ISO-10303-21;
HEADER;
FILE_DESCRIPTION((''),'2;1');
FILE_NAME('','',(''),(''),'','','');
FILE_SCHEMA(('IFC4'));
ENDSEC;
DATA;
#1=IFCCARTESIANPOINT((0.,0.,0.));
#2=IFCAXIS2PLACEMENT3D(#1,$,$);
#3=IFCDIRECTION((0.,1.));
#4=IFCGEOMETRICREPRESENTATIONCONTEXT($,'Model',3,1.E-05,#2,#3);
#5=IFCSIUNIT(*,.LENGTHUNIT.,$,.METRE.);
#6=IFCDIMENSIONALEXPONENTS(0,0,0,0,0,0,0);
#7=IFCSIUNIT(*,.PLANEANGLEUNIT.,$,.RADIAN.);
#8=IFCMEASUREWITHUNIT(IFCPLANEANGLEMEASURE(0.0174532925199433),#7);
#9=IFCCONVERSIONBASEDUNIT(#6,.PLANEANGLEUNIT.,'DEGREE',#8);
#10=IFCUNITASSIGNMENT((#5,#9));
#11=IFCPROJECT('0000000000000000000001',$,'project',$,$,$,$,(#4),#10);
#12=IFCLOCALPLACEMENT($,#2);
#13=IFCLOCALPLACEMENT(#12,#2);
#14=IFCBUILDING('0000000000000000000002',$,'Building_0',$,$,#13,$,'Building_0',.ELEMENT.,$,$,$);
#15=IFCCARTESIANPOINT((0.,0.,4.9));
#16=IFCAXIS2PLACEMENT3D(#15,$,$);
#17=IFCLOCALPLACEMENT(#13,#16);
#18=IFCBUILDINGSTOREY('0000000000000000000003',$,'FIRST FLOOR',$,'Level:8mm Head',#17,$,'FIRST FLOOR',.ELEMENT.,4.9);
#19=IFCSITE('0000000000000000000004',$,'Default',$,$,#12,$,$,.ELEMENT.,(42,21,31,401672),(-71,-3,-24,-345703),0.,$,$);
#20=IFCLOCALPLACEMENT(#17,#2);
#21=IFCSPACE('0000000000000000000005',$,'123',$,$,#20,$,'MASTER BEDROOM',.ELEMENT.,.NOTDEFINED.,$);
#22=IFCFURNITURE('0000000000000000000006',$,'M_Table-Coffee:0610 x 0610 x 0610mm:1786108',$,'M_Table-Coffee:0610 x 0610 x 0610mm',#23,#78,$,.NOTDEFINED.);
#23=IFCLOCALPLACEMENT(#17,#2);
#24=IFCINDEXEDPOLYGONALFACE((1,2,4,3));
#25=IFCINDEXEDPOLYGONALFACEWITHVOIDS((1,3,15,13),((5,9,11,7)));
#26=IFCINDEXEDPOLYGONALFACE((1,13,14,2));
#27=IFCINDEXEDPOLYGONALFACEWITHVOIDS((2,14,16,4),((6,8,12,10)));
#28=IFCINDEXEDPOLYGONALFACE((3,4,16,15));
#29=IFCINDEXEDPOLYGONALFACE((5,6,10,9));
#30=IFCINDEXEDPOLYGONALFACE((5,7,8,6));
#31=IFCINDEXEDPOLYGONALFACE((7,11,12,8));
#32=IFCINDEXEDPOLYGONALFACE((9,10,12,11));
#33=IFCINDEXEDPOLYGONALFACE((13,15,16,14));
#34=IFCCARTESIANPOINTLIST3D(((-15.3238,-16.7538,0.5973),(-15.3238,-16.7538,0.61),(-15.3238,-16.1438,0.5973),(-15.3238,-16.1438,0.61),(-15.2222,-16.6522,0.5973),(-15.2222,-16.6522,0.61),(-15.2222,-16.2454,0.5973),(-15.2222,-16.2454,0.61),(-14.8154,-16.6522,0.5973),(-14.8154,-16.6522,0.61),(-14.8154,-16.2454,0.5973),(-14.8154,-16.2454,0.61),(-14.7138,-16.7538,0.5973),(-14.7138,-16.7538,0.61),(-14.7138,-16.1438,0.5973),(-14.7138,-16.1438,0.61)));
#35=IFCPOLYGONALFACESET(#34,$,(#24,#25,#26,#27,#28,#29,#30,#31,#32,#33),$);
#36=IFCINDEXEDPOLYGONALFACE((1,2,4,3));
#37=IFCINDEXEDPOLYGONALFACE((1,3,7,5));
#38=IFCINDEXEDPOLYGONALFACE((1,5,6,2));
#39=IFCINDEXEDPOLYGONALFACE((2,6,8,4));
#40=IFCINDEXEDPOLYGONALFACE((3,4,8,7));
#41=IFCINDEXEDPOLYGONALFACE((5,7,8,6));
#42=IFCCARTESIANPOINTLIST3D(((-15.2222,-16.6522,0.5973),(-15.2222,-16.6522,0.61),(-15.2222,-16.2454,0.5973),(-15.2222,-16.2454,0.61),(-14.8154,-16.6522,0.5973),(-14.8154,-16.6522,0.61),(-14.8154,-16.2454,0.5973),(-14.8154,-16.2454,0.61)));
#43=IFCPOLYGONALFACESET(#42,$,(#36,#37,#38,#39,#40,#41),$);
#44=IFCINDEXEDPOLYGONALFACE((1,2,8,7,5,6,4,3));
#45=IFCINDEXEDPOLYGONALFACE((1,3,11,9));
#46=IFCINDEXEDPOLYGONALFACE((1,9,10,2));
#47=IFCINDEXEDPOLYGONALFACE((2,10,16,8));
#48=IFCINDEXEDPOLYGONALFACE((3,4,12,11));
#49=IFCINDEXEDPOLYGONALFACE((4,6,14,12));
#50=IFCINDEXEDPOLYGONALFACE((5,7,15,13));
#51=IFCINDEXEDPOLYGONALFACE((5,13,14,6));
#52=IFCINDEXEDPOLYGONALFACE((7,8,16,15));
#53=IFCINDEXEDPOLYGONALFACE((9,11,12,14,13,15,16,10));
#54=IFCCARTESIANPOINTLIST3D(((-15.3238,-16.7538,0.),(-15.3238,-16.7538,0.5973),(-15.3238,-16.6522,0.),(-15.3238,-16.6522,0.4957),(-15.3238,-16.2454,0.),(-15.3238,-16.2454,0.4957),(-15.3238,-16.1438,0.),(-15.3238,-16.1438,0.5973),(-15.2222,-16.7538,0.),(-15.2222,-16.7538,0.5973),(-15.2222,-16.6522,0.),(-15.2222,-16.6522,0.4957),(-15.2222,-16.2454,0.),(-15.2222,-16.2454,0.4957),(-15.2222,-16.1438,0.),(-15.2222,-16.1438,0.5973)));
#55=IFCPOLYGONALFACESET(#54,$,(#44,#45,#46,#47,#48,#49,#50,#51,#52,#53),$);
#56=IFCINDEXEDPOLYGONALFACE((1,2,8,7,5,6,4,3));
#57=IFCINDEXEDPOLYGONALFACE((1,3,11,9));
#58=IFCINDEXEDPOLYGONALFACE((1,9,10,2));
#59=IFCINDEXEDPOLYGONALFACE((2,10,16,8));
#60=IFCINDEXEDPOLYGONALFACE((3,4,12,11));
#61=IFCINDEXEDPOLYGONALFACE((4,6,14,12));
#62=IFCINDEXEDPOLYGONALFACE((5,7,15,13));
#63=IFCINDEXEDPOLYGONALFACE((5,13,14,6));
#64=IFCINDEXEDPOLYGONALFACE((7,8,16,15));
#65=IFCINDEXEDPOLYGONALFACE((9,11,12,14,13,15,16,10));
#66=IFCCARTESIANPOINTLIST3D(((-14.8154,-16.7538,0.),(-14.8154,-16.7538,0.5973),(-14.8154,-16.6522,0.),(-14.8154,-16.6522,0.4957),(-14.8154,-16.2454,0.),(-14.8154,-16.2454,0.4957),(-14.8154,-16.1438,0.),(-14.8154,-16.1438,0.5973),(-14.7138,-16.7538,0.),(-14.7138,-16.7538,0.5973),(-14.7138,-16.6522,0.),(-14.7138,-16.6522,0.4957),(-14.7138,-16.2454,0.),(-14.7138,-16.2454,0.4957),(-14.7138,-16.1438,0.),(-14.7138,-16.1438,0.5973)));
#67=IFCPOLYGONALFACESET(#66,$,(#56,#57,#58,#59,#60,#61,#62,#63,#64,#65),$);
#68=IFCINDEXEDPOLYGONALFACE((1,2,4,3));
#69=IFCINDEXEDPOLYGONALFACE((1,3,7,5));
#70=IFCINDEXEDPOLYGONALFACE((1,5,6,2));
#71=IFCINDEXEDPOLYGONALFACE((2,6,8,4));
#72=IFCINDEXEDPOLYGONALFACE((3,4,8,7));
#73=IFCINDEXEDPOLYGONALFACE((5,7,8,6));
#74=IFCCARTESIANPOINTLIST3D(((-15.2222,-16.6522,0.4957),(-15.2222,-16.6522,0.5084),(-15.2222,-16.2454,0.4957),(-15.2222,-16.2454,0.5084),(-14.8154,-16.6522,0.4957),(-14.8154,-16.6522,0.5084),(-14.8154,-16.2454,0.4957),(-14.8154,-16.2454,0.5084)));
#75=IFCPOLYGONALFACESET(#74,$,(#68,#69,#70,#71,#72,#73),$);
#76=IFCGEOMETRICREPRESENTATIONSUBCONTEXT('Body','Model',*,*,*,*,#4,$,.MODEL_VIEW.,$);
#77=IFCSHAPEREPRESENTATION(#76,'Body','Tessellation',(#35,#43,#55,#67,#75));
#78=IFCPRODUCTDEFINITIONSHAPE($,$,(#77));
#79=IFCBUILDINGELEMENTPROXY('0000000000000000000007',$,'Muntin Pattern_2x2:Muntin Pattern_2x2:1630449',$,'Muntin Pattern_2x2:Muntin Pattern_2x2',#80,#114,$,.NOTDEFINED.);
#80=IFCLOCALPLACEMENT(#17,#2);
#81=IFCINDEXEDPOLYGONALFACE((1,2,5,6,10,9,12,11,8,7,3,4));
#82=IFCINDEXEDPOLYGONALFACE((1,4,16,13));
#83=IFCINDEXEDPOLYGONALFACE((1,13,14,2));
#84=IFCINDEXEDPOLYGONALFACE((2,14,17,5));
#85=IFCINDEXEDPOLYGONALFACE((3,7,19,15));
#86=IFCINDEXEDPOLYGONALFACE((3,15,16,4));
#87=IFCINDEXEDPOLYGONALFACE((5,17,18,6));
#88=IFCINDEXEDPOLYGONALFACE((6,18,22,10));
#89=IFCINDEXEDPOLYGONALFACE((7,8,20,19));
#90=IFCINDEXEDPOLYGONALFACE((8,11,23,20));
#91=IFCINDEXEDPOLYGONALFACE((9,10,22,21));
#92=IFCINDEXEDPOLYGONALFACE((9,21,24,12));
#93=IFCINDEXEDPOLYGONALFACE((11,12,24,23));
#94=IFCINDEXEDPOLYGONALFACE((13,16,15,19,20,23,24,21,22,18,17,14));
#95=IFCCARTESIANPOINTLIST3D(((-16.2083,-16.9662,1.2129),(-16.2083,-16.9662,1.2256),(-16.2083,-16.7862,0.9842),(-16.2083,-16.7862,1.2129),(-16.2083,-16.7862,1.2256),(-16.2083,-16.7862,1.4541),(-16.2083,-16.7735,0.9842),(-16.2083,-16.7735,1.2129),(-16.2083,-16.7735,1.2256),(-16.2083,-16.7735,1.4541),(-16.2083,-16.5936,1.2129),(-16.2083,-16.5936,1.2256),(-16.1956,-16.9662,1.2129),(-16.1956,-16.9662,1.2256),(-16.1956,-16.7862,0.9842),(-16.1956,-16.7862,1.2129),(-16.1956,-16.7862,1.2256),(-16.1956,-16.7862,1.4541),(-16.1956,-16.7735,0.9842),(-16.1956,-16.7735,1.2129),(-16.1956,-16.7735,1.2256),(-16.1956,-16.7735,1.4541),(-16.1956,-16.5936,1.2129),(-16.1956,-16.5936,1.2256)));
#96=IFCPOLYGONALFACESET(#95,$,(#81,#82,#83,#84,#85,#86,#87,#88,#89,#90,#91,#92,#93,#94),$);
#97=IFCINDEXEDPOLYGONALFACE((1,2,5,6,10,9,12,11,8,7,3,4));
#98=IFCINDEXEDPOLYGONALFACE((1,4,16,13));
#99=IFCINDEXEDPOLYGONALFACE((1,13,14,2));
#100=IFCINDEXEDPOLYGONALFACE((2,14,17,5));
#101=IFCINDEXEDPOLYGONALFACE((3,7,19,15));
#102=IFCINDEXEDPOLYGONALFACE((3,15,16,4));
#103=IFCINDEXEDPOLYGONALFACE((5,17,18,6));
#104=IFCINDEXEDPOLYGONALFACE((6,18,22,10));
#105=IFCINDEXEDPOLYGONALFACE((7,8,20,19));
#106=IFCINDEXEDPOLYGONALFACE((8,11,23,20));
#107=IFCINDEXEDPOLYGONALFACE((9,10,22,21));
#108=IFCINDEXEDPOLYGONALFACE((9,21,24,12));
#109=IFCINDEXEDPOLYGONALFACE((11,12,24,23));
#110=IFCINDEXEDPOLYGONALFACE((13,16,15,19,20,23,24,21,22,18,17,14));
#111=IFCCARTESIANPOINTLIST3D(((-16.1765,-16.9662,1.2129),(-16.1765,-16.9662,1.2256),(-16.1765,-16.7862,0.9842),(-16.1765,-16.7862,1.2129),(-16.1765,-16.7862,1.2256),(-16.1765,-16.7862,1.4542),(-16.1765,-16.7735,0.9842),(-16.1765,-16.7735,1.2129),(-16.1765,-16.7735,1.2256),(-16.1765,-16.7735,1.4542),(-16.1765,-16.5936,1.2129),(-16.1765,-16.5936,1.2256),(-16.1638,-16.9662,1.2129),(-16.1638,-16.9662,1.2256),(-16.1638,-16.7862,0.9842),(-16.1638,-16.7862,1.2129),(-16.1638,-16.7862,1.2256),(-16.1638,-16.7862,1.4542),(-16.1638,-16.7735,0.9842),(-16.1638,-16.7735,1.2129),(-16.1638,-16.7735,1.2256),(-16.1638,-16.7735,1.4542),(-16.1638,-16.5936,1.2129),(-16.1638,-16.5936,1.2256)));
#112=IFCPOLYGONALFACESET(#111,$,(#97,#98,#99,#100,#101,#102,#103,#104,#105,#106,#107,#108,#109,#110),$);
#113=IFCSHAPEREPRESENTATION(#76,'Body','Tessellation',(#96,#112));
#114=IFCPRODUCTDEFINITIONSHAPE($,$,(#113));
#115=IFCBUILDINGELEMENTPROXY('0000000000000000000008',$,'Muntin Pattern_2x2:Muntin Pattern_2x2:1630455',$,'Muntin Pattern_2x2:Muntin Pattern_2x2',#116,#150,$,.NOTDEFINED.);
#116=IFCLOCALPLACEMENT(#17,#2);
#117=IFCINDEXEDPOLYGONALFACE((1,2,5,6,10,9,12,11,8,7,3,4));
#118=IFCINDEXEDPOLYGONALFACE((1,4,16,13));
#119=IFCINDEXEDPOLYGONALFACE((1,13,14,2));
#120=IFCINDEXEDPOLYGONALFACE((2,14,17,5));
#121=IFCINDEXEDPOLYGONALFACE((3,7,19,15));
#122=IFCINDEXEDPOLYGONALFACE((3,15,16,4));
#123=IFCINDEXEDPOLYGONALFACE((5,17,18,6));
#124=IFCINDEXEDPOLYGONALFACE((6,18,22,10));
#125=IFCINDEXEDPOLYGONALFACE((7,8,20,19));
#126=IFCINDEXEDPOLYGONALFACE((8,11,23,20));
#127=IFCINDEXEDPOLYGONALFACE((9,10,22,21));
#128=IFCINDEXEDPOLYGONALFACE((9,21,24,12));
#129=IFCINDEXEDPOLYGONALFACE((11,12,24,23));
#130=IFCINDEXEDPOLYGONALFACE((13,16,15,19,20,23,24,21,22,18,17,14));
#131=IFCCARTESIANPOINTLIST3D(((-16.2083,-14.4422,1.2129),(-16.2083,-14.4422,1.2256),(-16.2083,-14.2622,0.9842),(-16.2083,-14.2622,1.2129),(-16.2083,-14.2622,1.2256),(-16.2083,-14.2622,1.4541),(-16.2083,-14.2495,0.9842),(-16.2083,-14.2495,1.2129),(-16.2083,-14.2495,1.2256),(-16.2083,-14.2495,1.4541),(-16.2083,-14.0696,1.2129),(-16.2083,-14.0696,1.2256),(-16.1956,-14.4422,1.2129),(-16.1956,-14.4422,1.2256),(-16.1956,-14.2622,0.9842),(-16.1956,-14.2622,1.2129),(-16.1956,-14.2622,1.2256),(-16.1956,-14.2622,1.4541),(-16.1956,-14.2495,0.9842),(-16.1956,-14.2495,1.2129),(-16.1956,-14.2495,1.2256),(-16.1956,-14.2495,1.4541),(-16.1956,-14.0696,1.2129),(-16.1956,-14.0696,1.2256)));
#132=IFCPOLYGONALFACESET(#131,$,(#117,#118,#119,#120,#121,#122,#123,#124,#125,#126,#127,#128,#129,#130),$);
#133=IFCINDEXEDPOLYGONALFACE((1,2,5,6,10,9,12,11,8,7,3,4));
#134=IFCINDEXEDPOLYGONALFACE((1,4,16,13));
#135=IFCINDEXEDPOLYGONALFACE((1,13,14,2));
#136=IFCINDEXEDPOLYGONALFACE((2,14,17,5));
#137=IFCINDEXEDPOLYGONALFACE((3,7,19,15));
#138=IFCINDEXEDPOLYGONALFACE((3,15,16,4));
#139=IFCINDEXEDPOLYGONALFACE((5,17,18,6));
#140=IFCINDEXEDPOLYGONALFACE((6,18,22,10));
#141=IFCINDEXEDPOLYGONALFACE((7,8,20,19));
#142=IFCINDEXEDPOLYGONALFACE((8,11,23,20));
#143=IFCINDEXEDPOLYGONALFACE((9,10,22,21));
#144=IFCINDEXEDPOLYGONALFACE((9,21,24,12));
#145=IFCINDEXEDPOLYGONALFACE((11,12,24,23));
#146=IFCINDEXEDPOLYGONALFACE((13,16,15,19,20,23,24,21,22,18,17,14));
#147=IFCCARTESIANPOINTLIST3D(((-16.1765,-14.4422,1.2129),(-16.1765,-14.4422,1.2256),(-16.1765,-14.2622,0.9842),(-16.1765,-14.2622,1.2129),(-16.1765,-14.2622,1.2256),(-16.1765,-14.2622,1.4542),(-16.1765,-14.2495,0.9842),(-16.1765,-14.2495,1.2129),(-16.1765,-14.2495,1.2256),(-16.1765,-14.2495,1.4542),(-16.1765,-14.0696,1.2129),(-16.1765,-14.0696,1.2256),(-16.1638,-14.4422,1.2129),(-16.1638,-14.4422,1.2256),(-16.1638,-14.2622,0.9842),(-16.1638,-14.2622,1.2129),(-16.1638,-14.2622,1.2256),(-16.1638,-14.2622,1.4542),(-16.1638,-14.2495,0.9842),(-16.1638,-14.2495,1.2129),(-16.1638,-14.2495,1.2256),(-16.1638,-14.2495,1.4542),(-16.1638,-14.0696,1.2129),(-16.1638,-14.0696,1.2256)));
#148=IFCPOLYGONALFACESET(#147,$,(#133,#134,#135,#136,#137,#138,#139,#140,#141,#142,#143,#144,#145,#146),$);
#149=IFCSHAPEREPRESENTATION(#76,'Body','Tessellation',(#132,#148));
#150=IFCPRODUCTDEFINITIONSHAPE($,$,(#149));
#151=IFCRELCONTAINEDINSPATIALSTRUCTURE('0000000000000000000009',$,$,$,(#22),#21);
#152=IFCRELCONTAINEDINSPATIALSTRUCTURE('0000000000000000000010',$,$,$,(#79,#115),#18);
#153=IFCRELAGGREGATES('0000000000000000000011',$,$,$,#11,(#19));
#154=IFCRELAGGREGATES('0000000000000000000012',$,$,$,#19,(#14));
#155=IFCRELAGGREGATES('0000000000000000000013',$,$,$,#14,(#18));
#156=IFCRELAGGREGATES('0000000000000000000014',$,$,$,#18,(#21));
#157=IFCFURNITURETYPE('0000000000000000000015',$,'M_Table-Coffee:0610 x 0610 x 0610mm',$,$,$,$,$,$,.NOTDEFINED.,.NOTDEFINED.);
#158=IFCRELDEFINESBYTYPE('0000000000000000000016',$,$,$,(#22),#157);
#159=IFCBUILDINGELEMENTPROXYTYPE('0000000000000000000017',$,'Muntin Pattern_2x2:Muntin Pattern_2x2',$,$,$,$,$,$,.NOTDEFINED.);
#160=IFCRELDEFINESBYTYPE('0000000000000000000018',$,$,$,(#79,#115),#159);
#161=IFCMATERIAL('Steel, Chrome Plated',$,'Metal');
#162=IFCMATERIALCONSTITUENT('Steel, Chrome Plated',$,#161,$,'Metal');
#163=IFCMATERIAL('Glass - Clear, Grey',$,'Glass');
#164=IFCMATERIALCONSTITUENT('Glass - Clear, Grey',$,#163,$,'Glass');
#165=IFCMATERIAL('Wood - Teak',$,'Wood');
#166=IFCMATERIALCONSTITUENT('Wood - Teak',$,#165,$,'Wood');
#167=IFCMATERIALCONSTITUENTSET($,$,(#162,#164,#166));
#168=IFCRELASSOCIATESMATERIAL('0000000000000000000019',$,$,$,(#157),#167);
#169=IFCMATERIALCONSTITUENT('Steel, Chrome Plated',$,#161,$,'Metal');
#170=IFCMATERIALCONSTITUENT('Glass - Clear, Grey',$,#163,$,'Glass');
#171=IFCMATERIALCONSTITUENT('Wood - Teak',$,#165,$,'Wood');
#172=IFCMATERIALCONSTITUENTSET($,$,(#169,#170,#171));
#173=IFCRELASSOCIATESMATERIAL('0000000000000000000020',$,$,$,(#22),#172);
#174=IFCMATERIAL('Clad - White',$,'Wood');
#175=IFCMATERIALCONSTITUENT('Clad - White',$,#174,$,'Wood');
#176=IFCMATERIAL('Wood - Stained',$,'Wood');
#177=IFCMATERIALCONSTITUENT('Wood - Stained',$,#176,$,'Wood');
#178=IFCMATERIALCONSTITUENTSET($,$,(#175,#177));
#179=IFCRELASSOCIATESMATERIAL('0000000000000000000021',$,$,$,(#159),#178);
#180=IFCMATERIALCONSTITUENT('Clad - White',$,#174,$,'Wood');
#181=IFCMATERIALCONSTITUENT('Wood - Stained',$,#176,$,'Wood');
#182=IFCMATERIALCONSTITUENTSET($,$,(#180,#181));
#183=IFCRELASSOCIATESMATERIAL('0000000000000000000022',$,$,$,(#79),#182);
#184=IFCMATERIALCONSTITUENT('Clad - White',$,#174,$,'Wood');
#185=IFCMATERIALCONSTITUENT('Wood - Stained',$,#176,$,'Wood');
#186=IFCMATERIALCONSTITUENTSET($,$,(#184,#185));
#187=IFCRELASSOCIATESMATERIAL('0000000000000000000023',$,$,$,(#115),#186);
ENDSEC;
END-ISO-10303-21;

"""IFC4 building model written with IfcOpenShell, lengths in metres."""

from ifc_helpers import new_model, entity, si_unit, converted_unit, direction, frame, origin, place, context, subcontext, project, spatial, indexed_curve, outline, extrude, source, transform, mapped, material, constituent, constituent_set, type_object, type_shapes, element, save


model = new_model("IFC4")

# Units and contexts
model_context = context("Model", 3, precision=1e-05, world=origin(), true_north=direction((0.0, 1.0)))
body_context = subcontext(model_context, "Body", "Model", "MODEL_VIEW")
ifc_project = project(units=[si_unit("LENGTHUNIT", "METRE"), converted_unit("PLANEANGLEUNIT", "DEGREE", entity("IfcPlaneAngleMeasure", 0.0174532925199433), si_unit("PLANEANGLEUNIT", "RADIAN"), dimensions=[0, 0, 0, 0, 0, 0, 0])], contexts=[model_context])

# Site, building, storey
site_placement = place(None, origin())
site = spatial("IfcSite", under=ifc_project, at=site_placement, Name="Default", CompositionType="ELEMENT", RefLatitude=(42, 21, 31, 401672), RefLongitude=(-71, -3, -24, -345703), RefElevation=0.0)
building_placement = place(site_placement, origin())
building = spatial("IfcBuilding", under=site, at=building_placement, Name="Building_0", LongName="Building_0", CompositionType="ELEMENT")
storey_placement = place(building_placement, frame((0.0, 0.0, 4.9)))
storey = spatial("IfcBuildingStorey", under=building, at=storey_placement, Name="FIRST FLOOR", ObjectType="Level:8mm Head", LongName="FIRST FLOOR", CompositionType="ELEMENT", Elevation=4.9)

# Shared definitions
ifc_material_1 = material(Name="Clad - White", Category="Wood")

# Shared definitions
space_placement = place(storey_placement, origin())
space = spatial("IfcSpace", under=storey, at=space_placement, Name="123", LongName="MASTER BEDROOM", CompositionType="ELEMENT", PredefinedType="NOTDEFINED")

# Furniture
ifc_material_2 = material(Name="Steel, Chrome Plated", Category="Metal")
ifc_constituent_1 = constituent(ifc_material_2, Name="Steel, Chrome Plated", Category="Metal")
ifc_material_3 = material(Name="Glass - Clear, Grey", Category="Glass")
ifc_constituent_2 = constituent(ifc_material_3, Name="Glass - Clear, Grey", Category="Glass")
ifc_material_4 = material(Name="Wood - Teak", Category="Wood")
ifc_constituent_3 = constituent(ifc_material_4, Name="Wood - Teak", Category="Wood")
ifc_constituent_set_1 = constituent_set(constituents=[ifc_constituent_1, ifc_constituent_2, ifc_constituent_3])
ifc_constituent_4 = constituent(ifc_material_2, Name="Steel, Chrome Plated", Category="Metal")
ifc_constituent_5 = constituent(ifc_material_3, Name="Glass - Clear, Grey", Category="Glass")
ifc_constituent_6 = constituent(ifc_material_4, Name="Wood - Teak", Category="Wood")
ifc_constituent_set_2 = constituent_set(constituents=[ifc_constituent_4, ifc_constituent_5, ifc_constituent_6])
furniture_type = type_object("IfcFurnitureType", Name="M_Table-Coffee:0610 x 0610 x 0610mm", AssemblyPlace="NOTDEFINED", PredefinedType="NOTDEFINED", material=ifc_constituent_set_2)
shared_shape_1 = source(origin(), body_context, "Body", "SweptSolid", [
    extrude(outline(indexed_curve([(-0.305, -0.305), (0.305, -0.305), (0.305, 0.305), (-0.305, 0.305), (-0.305, -0.305)], self_intersect=False), holes=[indexed_curve([(-0.2034, -0.2034), (-0.2034, 0.2034), (0.2034, 0.2034), (0.2034, -0.2034), (-0.2034, -0.2034)], self_intersect=False)]), frame((0.0183, 0.0952, 0.5973), z_axis=(0.0, 0.0, 1.0), x_axis=(-1.0, 0.0, 0.0)), (0.0, 0.0, 1.0), 0.0127),
    extrude(outline(indexed_curve([(-0.2034, -0.2034), (0.2034, -0.2034), (0.2034, 0.2034), (-0.2034, 0.2034), (-0.2034, -0.2034)], self_intersect=False)), frame((0.0183, 0.0952, 0.5973), z_axis=(0.0, 0.0, 1.0), x_axis=(-1.0, 0.0, 0.0)), (0.0, 0.0, 1.0), 0.0127),
    extrude(outline(indexed_curve([(-0.305, -0.3241), (0.305, -0.3241), (0.305, 0.2733), (0.2034, 0.2733), (0.2034, -0.2224), (-0.2034, -0.2224), (-0.2034, 0.2733), (-0.305, 0.2733), (-0.305, -0.3241)], self_intersect=False)), frame((-0.2867, 0.0952, 0.2733), z_axis=(1.0, 0.0, 0.0), x_axis=(0.0, -1.0, 0.0)), (0.0, 0.0, 1.0), 0.1016),
    extrude(outline(indexed_curve([(-0.2732, -0.305), (0.324, -0.305), (0.324, 0.305), (-0.2732, 0.305), (-0.2732, 0.2034), (0.2225, 0.2034), (0.2225, -0.2034), (-0.2732, -0.2034), (-0.2732, -0.305)], self_intersect=False)), frame((0.2217, 0.0952, 0.2732), z_axis=(1.0, 0.0, 0.0), x_axis=(0.0, 0.0, 1.0)), (0.0, 0.0, 1.0), 0.1016),
    extrude(outline(indexed_curve([(-0.2034, -0.2034), (0.2034, -0.2034), (0.2034, 0.2034), (-0.2034, 0.2034), (-0.2034, -0.2034)], self_intersect=False)), frame((0.0183, 0.0952, 0.4957), z_axis=(0.0, 0.0, 1.0), x_axis=(-1.0, 0.0, 0.0)), (0.0, 0.0, 1.0), 0.0127),
])
type_shapes(furniture_type, [shared_shape_1])
furniture_placement = place(space_placement, frame((-15.0371, -16.544, 0.0)))
element("IfcFurniture", 1, at=furniture_placement, inside=space, type_object=furniture_type, material=ifc_constituent_set_1, Name="M_Table-Coffee:0610 x 0610 x 0610mm:1786108", ObjectType="M_Table-Coffee:0610 x 0610 x 0610mm", PredefinedType="NOTDEFINED", context=body_context, shape_type="MappedRepresentation", body=[
    mapped(shared_shape_1, transform((0.0, 0.0, 0.0), scale=1.0)),
])

# Building element proxies
ifc_constituent_7 = constituent(ifc_material_1, Name="Clad - White", Category="Wood")
ifc_material_5 = material(Name="Wood - Stained", Category="Wood")
ifc_constituent_8 = constituent(ifc_material_5, Name="Wood - Stained", Category="Wood")
ifc_constituent_set_3 = constituent_set(constituents=[ifc_constituent_7, ifc_constituent_8])
ifc_constituent_9 = constituent(ifc_material_1, Name="Clad - White", Category="Wood")
ifc_constituent_10 = constituent(ifc_material_5, Name="Wood - Stained", Category="Wood")
ifc_constituent_set_4 = constituent_set(constituents=[ifc_constituent_9, ifc_constituent_10])
building_element_proxy_type_1 = type_object("IfcBuildingElementProxyType", Name="Muntin Pattern_2x2:Muntin Pattern_2x2", PredefinedType="NOTDEFINED", material=ifc_constituent_set_4)
shared_shape_2 = source(origin(), body_context, "Body", "SweptSolid", [
    extrude(outline(indexed_curve([(0.0064, -0.0064), (0.2349, -0.0064), (0.2349, 0.0063), (0.0064, 0.0063), (0.0064, 0.1863), (-0.0063, 0.1863), (-0.0063, 0.0063), (-0.235, 0.0063), (-0.235, -0.0064), (-0.0063, -0.0064), (-0.0063, -0.1863), (0.0064, -0.1863), (0.0064, -0.0064)], self_intersect=False)), frame((0.0, 0.0095, 0.235), z_axis=(0.0, 1.0, 0.0), x_axis=(0.0, 0.0, 1.0)), (0.0, 0.0, 1.0), 0.0127),
    extrude(outline(indexed_curve([(0.0064, -0.0064), (0.235, -0.0064), (0.235, 0.0063), (0.0064, 0.0063), (0.0064, 0.1863), (-0.0063, 0.1863), (-0.0063, 0.0063), (-0.235, 0.0063), (-0.235, -0.0064), (-0.0063, -0.0064), (-0.0063, -0.1863), (0.0064, -0.1863), (0.0064, -0.0064)], self_intersect=False)), frame((0.0, -0.0222, 0.235), z_axis=(0.0, 1.0, 0.0), x_axis=(0.0, 0.0, 1.0)), (0.0, 0.0, 1.0), 0.0127),
])
type_shapes(building_element_proxy_type_1, [shared_shape_2])
proxy_1_placement = place(storey_placement, frame((-16.1861, -16.7799, 0.9842), z_axis=(0.0, 0.0, 1.0), x_axis=(0.0, 1.0, 0.0)))
element("IfcBuildingElementProxy", 2, at=proxy_1_placement, inside=storey, type_object=building_element_proxy_type_1, material=ifc_constituent_set_3, Name="Muntin Pattern_2x2:Muntin Pattern_2x2:1630449", ObjectType="Muntin Pattern_2x2:Muntin Pattern_2x2", PredefinedType="NOTDEFINED", context=body_context, shape_type="MappedRepresentation", body=[
    mapped(shared_shape_2, transform((0.0, 0.0, 0.0), scale=1.0)),
])
ifc_constituent_11 = constituent(ifc_material_1, Name="Clad - White", Category="Wood")
ifc_constituent_12 = constituent(ifc_material_5, Name="Wood - Stained", Category="Wood")
ifc_constituent_set_5 = constituent_set(constituents=[ifc_constituent_11, ifc_constituent_12])
proxy_2_placement = place(storey_placement, frame((-16.1861, -14.2559, 0.9842), z_axis=(0.0, 0.0, 1.0), x_axis=(0.0, 1.0, 0.0)))
element("IfcBuildingElementProxy", 3, at=proxy_2_placement, inside=storey, type_object=building_element_proxy_type_1, material=ifc_constituent_set_5, Name="Muntin Pattern_2x2:Muntin Pattern_2x2:1630455", ObjectType="Muntin Pattern_2x2:Muntin Pattern_2x2", PredefinedType="NOTDEFINED", context=body_context, shape_type="MappedRepresentation", body=[
    mapped(shared_shape_2, transform((0.0, 0.0, 0.0), scale=1.0)),
])

save(model, "model.ifc")
